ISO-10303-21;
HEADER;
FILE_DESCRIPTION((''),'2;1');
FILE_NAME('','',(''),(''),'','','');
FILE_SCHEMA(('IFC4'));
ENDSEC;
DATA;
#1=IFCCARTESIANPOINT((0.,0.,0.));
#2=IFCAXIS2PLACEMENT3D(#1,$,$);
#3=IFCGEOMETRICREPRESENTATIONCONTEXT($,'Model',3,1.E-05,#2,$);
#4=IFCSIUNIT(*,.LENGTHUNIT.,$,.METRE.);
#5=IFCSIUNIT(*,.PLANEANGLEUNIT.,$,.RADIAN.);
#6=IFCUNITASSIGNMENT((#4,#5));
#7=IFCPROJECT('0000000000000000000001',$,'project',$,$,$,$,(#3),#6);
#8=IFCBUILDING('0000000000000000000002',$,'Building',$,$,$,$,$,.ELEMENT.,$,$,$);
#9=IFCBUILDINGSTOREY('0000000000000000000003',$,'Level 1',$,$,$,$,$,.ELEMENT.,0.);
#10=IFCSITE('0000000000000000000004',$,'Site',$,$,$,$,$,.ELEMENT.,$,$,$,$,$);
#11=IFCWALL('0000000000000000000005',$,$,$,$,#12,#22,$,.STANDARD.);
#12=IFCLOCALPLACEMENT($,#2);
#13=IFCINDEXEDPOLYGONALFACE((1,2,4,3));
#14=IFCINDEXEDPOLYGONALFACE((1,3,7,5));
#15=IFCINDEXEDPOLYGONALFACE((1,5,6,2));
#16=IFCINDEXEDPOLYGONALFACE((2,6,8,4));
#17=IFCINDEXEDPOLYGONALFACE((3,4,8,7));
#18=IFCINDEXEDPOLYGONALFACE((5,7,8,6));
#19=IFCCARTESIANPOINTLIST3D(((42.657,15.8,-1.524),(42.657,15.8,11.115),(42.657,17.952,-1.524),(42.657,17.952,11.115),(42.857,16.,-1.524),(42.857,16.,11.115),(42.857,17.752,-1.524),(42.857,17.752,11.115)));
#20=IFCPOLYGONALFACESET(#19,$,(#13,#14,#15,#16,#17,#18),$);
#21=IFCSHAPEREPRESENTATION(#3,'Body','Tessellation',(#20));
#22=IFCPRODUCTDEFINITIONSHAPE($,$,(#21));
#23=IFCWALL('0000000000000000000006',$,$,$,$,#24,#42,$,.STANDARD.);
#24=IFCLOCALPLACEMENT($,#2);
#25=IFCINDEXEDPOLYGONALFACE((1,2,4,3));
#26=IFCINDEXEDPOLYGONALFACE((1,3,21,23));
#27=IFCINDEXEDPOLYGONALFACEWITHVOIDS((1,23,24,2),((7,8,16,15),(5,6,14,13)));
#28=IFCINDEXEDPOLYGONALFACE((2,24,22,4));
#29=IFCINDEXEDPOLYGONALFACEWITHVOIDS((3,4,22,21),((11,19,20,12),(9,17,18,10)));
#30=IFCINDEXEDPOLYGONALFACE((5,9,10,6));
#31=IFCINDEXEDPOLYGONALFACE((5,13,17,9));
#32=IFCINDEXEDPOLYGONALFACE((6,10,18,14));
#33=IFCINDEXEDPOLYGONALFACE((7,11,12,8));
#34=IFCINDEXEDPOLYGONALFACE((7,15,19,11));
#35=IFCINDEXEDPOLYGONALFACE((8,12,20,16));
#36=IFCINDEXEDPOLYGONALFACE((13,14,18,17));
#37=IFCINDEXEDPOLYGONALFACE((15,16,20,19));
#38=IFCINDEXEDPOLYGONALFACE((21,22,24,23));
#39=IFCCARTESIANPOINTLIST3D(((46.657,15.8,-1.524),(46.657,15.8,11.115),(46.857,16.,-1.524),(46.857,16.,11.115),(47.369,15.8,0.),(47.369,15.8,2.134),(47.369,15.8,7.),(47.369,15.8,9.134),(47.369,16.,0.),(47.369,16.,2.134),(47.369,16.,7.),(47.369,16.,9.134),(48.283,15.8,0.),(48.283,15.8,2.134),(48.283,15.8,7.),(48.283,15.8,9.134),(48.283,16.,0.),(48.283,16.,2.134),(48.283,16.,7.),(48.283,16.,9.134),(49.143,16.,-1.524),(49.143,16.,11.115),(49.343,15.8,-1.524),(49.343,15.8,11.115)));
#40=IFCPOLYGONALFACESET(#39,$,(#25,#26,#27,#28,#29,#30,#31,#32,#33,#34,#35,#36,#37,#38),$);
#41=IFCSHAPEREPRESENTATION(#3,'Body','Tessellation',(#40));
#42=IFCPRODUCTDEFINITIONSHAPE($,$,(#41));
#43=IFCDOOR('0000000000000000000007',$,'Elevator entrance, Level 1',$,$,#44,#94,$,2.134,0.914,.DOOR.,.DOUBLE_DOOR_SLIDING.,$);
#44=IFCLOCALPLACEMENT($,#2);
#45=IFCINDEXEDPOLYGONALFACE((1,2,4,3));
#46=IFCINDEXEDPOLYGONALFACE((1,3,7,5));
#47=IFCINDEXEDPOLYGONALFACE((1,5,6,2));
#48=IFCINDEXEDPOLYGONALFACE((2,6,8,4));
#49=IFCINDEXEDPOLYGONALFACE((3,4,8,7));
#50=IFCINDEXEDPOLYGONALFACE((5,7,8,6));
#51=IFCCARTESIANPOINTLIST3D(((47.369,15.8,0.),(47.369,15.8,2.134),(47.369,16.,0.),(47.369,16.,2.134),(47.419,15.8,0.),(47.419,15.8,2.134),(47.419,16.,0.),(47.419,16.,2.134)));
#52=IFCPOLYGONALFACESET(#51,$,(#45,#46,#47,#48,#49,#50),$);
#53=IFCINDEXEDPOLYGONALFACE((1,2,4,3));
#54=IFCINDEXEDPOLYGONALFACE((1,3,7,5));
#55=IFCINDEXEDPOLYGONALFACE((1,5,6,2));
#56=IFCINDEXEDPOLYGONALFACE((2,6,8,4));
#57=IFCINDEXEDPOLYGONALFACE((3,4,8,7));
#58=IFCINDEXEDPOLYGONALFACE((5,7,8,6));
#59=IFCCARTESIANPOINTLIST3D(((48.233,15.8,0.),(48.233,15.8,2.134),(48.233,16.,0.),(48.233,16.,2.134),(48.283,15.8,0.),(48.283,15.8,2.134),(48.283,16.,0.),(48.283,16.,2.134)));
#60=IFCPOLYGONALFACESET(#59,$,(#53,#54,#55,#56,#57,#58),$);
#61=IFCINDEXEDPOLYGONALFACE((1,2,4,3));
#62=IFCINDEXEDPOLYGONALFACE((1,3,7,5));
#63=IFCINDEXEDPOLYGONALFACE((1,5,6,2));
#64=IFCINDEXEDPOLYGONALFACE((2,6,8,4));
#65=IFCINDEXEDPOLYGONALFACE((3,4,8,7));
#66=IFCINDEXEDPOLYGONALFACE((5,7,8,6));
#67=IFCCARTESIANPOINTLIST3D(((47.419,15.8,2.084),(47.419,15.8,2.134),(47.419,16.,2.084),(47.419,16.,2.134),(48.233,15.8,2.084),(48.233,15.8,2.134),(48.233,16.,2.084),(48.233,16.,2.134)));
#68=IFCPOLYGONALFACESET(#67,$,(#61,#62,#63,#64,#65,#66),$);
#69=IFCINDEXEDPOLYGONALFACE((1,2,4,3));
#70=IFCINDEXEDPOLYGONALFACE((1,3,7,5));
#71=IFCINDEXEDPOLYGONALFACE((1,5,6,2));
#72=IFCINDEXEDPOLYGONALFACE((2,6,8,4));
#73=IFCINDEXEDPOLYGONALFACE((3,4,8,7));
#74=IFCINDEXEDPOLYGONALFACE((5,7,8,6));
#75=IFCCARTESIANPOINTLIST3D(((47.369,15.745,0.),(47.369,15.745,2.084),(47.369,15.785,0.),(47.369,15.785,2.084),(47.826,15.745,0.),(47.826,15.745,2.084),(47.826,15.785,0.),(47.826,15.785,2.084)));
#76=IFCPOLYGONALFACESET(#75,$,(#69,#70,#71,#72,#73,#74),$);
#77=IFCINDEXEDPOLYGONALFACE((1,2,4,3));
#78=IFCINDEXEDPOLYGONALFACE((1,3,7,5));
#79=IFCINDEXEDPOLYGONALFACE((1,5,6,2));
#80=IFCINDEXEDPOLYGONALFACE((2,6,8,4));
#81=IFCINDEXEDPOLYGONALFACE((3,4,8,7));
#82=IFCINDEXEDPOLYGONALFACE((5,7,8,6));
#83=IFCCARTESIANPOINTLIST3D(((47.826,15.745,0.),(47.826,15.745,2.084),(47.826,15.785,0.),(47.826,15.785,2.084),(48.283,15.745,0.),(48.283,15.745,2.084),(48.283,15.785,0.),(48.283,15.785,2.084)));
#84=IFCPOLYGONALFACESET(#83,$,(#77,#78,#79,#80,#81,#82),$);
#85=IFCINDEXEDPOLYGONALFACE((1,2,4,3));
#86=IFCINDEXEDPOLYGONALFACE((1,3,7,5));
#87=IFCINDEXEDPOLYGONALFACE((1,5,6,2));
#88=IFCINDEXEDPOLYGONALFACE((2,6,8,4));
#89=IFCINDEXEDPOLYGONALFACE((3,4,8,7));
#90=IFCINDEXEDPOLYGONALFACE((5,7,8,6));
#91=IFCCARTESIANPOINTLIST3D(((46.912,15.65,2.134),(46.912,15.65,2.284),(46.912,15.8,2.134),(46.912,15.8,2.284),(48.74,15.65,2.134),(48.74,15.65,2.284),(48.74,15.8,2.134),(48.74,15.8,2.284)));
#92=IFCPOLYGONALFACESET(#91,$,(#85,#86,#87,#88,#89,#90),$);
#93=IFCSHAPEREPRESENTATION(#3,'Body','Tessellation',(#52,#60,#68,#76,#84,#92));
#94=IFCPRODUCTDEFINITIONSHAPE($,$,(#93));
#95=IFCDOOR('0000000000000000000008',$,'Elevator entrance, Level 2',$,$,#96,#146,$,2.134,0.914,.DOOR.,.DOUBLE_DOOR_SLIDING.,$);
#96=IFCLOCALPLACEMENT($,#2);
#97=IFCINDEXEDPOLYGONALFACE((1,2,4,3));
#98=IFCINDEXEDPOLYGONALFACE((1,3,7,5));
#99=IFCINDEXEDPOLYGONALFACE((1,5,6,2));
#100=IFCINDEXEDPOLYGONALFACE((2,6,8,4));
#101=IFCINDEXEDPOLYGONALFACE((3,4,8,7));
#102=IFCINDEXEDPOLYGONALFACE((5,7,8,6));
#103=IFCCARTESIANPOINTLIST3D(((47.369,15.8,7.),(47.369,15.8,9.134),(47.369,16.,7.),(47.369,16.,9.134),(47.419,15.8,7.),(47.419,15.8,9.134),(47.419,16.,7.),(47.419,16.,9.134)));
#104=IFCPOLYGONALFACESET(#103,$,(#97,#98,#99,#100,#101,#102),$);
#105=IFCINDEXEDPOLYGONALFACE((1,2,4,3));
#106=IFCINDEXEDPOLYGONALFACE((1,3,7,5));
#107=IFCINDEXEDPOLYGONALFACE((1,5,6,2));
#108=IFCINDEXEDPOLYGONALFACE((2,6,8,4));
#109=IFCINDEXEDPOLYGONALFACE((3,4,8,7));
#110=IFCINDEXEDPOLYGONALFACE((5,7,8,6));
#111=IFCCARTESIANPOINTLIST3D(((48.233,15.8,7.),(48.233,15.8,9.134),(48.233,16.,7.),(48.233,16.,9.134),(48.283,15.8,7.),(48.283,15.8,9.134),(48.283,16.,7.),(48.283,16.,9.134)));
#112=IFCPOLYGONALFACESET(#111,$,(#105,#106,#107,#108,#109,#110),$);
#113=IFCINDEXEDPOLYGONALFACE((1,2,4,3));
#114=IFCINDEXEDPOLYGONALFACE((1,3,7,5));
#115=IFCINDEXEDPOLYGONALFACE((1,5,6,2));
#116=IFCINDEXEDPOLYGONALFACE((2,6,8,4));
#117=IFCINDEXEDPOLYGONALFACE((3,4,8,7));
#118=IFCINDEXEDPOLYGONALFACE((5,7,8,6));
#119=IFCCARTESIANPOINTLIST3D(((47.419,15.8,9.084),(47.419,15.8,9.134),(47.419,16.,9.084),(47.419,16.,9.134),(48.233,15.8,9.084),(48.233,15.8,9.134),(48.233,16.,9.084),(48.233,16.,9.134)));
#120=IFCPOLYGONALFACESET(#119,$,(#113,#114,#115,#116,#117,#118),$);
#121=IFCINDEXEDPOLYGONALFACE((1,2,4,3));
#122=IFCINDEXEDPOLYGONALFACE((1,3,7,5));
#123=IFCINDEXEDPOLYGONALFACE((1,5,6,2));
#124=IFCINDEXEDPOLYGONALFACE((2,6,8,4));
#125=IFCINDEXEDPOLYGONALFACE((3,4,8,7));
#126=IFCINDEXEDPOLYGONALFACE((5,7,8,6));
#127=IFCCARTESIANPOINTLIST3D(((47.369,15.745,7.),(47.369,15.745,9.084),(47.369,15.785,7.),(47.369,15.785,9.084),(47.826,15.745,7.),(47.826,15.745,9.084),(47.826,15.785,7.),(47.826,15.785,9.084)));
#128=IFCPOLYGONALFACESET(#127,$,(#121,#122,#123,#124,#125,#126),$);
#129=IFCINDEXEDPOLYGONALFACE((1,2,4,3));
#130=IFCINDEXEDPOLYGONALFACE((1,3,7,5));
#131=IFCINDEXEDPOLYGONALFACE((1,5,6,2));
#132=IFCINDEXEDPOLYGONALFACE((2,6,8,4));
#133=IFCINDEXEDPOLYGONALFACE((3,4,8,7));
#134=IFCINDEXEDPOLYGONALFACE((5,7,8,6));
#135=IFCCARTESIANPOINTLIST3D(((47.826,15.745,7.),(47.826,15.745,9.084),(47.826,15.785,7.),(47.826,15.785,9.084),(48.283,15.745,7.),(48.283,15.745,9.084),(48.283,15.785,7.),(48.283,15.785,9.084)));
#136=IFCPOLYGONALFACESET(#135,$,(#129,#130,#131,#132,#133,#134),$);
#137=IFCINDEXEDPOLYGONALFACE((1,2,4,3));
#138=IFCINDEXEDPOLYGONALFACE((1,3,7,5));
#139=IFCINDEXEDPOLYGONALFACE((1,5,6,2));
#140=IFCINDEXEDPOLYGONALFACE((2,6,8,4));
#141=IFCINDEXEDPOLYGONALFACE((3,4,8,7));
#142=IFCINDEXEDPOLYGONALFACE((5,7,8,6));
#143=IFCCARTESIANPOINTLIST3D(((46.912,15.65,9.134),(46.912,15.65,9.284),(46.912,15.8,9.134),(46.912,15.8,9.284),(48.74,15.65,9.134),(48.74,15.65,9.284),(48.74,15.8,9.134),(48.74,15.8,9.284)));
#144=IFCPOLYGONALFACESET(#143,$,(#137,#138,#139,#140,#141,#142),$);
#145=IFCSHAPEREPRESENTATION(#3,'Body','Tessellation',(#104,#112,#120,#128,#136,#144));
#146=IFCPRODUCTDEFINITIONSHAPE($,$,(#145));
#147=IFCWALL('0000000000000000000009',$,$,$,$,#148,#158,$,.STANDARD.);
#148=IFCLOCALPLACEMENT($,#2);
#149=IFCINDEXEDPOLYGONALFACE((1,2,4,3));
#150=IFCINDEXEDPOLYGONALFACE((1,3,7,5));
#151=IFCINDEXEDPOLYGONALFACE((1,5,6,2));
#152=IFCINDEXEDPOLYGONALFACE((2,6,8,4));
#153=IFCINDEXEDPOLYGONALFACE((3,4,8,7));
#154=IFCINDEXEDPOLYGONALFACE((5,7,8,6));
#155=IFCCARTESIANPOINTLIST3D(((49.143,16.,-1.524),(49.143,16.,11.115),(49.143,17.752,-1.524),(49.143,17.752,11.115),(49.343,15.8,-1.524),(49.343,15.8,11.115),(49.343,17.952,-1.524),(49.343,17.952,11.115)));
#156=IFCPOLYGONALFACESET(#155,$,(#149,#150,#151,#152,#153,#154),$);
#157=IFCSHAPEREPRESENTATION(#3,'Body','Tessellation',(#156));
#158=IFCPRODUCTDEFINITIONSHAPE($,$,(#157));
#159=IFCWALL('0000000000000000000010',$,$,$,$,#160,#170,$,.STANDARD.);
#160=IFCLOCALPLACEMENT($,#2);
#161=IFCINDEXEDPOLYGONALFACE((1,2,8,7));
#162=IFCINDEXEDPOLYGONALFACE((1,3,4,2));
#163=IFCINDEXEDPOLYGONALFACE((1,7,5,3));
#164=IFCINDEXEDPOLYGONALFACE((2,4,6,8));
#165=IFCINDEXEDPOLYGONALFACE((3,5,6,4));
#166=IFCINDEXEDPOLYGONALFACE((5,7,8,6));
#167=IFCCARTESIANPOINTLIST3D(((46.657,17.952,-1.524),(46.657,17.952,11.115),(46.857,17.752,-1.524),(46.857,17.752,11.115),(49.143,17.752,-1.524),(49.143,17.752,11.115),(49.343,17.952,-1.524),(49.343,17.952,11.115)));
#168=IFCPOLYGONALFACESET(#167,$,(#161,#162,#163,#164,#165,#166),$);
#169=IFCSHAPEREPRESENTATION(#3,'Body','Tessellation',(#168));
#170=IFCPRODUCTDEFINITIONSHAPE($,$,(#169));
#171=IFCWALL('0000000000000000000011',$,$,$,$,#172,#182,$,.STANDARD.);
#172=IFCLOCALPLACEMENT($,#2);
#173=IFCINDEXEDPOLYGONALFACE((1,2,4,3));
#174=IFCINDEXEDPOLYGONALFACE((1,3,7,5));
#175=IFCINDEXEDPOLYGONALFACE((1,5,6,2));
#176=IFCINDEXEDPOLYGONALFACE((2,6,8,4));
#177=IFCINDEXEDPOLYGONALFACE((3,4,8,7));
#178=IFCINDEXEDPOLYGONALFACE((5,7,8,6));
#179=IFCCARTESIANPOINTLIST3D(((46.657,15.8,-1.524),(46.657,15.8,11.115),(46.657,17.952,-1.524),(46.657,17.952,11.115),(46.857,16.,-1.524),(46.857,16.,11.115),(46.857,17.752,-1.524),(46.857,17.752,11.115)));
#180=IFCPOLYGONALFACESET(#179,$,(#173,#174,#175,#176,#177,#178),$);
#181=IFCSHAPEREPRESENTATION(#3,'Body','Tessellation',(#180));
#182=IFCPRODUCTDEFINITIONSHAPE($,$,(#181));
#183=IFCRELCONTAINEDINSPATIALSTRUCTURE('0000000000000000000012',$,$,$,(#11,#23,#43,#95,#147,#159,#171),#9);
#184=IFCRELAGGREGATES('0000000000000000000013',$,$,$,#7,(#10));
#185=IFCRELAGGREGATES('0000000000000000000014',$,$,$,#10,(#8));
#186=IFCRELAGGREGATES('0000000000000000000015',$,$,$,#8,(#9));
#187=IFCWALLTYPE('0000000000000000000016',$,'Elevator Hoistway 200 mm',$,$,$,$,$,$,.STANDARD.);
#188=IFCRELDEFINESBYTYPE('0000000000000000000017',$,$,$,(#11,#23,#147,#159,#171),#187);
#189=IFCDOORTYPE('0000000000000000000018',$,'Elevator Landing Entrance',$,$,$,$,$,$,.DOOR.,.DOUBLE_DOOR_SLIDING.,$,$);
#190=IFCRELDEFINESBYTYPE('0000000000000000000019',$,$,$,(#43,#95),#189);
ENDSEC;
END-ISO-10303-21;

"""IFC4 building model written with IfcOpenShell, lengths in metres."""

from ifc_helpers import new_model, si_unit, frame, frame_2d, origin, origin_with_axes, origin_2d, place, context, project, spatial, polyline, rectangle, outline, extrude, type_object, element, fill, save


model = new_model("IFC4")

# Units and contexts
model_context = context("Model", 3, precision=1e-05, world=origin())
ifc_project = project(units=[si_unit("LENGTHUNIT", "METRE"), si_unit("PLANEANGLEUNIT", "RADIAN")], contexts=[model_context])

# Site, building, storey
site = spatial("IfcSite", under=ifc_project, Name="Site", CompositionType="ELEMENT")
building = spatial("IfcBuilding", under=site, Name="Building", CompositionType="ELEMENT")
storey = spatial("IfcBuildingStorey", under=building, Name="Level 1", CompositionType="ELEMENT", Elevation=0.0)

# Shared definitions
wall_type = type_object("IfcWallType", Name="Elevator Hoistway 200 mm", PredefinedType="STANDARD")
door_type = type_object("IfcDoorType", Name="Elevator Landing Entrance", OperationType="DOUBLE_DOOR_SLIDING", PredefinedType="DOOR")

# Wall
wall_1_placement = place(None, frame((42.757, 17.852, -1.524), z_axis=(0.0, 0.0, 1.0), x_axis=(0.0, -1.0, 0.0)))
element("IfcWall", 1, at=wall_1_placement, inside=storey, type_object=wall_type, PredefinedType="STANDARD", context=model_context, shape_type="SweptSolid", body=[
    extrude(outline(polyline([(-0.1, -0.1), (2.052, -0.1), (1.852, 0.1), (0.1, 0.1), (-0.1, -0.1)])), origin(), (0.0, 0.0, 1.0), 12.639),
])

# Wall, openings, doors
wall_2_placement = place(None, frame((46.757, 15.9, -1.524), z_axis=(0.0, 0.0, 1.0), x_axis=(1.0, 0.0, 0.0)))
wall_2 = element("IfcWall", 2, at=wall_2_placement, inside=storey, type_object=wall_type, PredefinedType="STANDARD", context=model_context, shape_type="SweptSolid", body=[
    extrude(outline(polyline([(-0.1, -0.1), (2.586, -0.1), (2.386, 0.1), (0.1, 0.1), (-0.1, -0.1)])), origin(), (0.0, 0.0, 1.0), 12.639),
])
opening_1_placement = place(wall_2_placement, frame((1.069, 0.0, 1.524), z_axis=(0.0, 0.0, 1.0), x_axis=(1.0, 0.0, 0.0)))
opening_1 = element("IfcOpeningElement", 3, at=opening_1_placement, cuts=wall_2, PredefinedType="OPENING", context=model_context, shape_type="SweptSolid", body=[
    extrude(rectangle(XDim=0.914, YDim=0.202, at=origin_2d()), origin(), (0.0, 0.0, 1.0), 2.134),
])
opening_2_placement = place(wall_2_placement, frame((1.069, 0.0, 8.524), z_axis=(0.0, 0.0, 1.0), x_axis=(1.0, 0.0, 0.0)))
opening_2 = element("IfcOpeningElement", 4, at=opening_2_placement, cuts=wall_2, PredefinedType="OPENING", context=model_context, shape_type="SweptSolid", body=[
    extrude(rectangle(XDim=0.914, YDim=0.202, at=origin_2d()), origin(), (0.0, 0.0, 1.0), 2.134),
])
door_1_placement = place(opening_1_placement, origin_with_axes())
door_1 = element("IfcDoor", 5, at=door_1_placement, inside=storey, type_object=door_type, Name="Elevator entrance, Level 1", OperationType="DOUBLE_DOOR_SLIDING", OverallHeight=2.134, OverallWidth=0.914, PredefinedType="DOOR", context=model_context, shape_type="SweptSolid", body=[
    extrude(rectangle(XDim=0.05, YDim=0.2, at=frame_2d((-0.432, 0.0))), origin(), (0.0, 0.0, 1.0), 2.134),
    extrude(rectangle(XDim=0.05, YDim=0.2, at=frame_2d((0.432, 0.0))), origin(), (0.0, 0.0, 1.0), 2.134),
    extrude(rectangle(XDim=0.814, YDim=0.2, at=origin_2d()), frame((0.0, 0.0, 2.084)), (0.0, 0.0, 1.0), 0.05),
    extrude(rectangle(XDim=0.457, YDim=0.04, at=frame_2d((-0.2285, -0.135))), origin(), (0.0, 0.0, 1.0), 2.084),
    extrude(rectangle(XDim=0.457, YDim=0.04, at=frame_2d((0.2285, -0.135))), origin(), (0.0, 0.0, 1.0), 2.084),
    extrude(rectangle(XDim=1.828, YDim=0.15, at=frame_2d((0.0, -0.175))), frame((0.0, 0.0, 2.134)), (0.0, 0.0, 1.0), 0.15),
])
fill(opening_1, door_1)
door_2_placement = place(opening_2_placement, origin_with_axes())
door_2 = element("IfcDoor", 6, at=door_2_placement, inside=storey, type_object=door_type, Name="Elevator entrance, Level 2", OperationType="DOUBLE_DOOR_SLIDING", OverallHeight=2.134, OverallWidth=0.914, PredefinedType="DOOR", context=model_context, shape_type="SweptSolid", body=[
    extrude(rectangle(XDim=0.05, YDim=0.2, at=frame_2d((-0.432, 0.0))), origin(), (0.0, 0.0, 1.0), 2.134),
    extrude(rectangle(XDim=0.05, YDim=0.2, at=frame_2d((0.432, 0.0))), origin(), (0.0, 0.0, 1.0), 2.134),
    extrude(rectangle(XDim=0.814, YDim=0.2, at=origin_2d()), frame((0.0, 0.0, 2.084)), (0.0, 0.0, 1.0), 0.05),
    extrude(rectangle(XDim=0.457, YDim=0.04, at=frame_2d((-0.2285, -0.135))), origin(), (0.0, 0.0, 1.0), 2.084),
    extrude(rectangle(XDim=0.457, YDim=0.04, at=frame_2d((0.2285, -0.135))), origin(), (0.0, 0.0, 1.0), 2.084),
    extrude(rectangle(XDim=1.828, YDim=0.15, at=frame_2d((0.0, -0.175))), frame((0.0, 0.0, 2.134)), (0.0, 0.0, 1.0), 0.15),
])
fill(opening_2, door_2)

# Walls
wall_3_placement = place(None, frame((49.243, 15.9, -1.524), z_axis=(0.0, 0.0, 1.0), x_axis=(0.0, 1.0, 0.0)))
element("IfcWall", 7, at=wall_3_placement, inside=storey, type_object=wall_type, PredefinedType="STANDARD", context=model_context, shape_type="SweptSolid", body=[
    extrude(outline(polyline([(-0.1, -0.1), (2.052, -0.1), (1.852, 0.1), (0.1, 0.1), (-0.1, -0.1)])), origin(), (0.0, 0.0, 1.0), 12.639),
])
wall_4_placement = place(None, frame((49.243, 17.852, -1.524), z_axis=(0.0, 0.0, 1.0), x_axis=(-1.0, 0.0, 0.0)))
element("IfcWall", 8, at=wall_4_placement, inside=storey, type_object=wall_type, PredefinedType="STANDARD", context=model_context, shape_type="SweptSolid", body=[
    extrude(outline(polyline([(-0.1, -0.1), (2.586, -0.1), (2.386, 0.1), (0.1, 0.1), (-0.1, -0.1)])), origin(), (0.0, 0.0, 1.0), 12.639),
])
wall_5_placement = place(None, frame((46.757, 17.852, -1.524), z_axis=(0.0, 0.0, 1.0), x_axis=(0.0, -1.0, 0.0)))
element("IfcWall", 9, at=wall_5_placement, inside=storey, type_object=wall_type, PredefinedType="STANDARD", context=model_context, shape_type="SweptSolid", body=[
    extrude(outline(polyline([(-0.1, -0.1), (2.052, -0.1), (1.852, 0.1), (0.1, 0.1), (-0.1, -0.1)])), origin(), (0.0, 0.0, 1.0), 12.639),
])

save(model, "model.ifc")
